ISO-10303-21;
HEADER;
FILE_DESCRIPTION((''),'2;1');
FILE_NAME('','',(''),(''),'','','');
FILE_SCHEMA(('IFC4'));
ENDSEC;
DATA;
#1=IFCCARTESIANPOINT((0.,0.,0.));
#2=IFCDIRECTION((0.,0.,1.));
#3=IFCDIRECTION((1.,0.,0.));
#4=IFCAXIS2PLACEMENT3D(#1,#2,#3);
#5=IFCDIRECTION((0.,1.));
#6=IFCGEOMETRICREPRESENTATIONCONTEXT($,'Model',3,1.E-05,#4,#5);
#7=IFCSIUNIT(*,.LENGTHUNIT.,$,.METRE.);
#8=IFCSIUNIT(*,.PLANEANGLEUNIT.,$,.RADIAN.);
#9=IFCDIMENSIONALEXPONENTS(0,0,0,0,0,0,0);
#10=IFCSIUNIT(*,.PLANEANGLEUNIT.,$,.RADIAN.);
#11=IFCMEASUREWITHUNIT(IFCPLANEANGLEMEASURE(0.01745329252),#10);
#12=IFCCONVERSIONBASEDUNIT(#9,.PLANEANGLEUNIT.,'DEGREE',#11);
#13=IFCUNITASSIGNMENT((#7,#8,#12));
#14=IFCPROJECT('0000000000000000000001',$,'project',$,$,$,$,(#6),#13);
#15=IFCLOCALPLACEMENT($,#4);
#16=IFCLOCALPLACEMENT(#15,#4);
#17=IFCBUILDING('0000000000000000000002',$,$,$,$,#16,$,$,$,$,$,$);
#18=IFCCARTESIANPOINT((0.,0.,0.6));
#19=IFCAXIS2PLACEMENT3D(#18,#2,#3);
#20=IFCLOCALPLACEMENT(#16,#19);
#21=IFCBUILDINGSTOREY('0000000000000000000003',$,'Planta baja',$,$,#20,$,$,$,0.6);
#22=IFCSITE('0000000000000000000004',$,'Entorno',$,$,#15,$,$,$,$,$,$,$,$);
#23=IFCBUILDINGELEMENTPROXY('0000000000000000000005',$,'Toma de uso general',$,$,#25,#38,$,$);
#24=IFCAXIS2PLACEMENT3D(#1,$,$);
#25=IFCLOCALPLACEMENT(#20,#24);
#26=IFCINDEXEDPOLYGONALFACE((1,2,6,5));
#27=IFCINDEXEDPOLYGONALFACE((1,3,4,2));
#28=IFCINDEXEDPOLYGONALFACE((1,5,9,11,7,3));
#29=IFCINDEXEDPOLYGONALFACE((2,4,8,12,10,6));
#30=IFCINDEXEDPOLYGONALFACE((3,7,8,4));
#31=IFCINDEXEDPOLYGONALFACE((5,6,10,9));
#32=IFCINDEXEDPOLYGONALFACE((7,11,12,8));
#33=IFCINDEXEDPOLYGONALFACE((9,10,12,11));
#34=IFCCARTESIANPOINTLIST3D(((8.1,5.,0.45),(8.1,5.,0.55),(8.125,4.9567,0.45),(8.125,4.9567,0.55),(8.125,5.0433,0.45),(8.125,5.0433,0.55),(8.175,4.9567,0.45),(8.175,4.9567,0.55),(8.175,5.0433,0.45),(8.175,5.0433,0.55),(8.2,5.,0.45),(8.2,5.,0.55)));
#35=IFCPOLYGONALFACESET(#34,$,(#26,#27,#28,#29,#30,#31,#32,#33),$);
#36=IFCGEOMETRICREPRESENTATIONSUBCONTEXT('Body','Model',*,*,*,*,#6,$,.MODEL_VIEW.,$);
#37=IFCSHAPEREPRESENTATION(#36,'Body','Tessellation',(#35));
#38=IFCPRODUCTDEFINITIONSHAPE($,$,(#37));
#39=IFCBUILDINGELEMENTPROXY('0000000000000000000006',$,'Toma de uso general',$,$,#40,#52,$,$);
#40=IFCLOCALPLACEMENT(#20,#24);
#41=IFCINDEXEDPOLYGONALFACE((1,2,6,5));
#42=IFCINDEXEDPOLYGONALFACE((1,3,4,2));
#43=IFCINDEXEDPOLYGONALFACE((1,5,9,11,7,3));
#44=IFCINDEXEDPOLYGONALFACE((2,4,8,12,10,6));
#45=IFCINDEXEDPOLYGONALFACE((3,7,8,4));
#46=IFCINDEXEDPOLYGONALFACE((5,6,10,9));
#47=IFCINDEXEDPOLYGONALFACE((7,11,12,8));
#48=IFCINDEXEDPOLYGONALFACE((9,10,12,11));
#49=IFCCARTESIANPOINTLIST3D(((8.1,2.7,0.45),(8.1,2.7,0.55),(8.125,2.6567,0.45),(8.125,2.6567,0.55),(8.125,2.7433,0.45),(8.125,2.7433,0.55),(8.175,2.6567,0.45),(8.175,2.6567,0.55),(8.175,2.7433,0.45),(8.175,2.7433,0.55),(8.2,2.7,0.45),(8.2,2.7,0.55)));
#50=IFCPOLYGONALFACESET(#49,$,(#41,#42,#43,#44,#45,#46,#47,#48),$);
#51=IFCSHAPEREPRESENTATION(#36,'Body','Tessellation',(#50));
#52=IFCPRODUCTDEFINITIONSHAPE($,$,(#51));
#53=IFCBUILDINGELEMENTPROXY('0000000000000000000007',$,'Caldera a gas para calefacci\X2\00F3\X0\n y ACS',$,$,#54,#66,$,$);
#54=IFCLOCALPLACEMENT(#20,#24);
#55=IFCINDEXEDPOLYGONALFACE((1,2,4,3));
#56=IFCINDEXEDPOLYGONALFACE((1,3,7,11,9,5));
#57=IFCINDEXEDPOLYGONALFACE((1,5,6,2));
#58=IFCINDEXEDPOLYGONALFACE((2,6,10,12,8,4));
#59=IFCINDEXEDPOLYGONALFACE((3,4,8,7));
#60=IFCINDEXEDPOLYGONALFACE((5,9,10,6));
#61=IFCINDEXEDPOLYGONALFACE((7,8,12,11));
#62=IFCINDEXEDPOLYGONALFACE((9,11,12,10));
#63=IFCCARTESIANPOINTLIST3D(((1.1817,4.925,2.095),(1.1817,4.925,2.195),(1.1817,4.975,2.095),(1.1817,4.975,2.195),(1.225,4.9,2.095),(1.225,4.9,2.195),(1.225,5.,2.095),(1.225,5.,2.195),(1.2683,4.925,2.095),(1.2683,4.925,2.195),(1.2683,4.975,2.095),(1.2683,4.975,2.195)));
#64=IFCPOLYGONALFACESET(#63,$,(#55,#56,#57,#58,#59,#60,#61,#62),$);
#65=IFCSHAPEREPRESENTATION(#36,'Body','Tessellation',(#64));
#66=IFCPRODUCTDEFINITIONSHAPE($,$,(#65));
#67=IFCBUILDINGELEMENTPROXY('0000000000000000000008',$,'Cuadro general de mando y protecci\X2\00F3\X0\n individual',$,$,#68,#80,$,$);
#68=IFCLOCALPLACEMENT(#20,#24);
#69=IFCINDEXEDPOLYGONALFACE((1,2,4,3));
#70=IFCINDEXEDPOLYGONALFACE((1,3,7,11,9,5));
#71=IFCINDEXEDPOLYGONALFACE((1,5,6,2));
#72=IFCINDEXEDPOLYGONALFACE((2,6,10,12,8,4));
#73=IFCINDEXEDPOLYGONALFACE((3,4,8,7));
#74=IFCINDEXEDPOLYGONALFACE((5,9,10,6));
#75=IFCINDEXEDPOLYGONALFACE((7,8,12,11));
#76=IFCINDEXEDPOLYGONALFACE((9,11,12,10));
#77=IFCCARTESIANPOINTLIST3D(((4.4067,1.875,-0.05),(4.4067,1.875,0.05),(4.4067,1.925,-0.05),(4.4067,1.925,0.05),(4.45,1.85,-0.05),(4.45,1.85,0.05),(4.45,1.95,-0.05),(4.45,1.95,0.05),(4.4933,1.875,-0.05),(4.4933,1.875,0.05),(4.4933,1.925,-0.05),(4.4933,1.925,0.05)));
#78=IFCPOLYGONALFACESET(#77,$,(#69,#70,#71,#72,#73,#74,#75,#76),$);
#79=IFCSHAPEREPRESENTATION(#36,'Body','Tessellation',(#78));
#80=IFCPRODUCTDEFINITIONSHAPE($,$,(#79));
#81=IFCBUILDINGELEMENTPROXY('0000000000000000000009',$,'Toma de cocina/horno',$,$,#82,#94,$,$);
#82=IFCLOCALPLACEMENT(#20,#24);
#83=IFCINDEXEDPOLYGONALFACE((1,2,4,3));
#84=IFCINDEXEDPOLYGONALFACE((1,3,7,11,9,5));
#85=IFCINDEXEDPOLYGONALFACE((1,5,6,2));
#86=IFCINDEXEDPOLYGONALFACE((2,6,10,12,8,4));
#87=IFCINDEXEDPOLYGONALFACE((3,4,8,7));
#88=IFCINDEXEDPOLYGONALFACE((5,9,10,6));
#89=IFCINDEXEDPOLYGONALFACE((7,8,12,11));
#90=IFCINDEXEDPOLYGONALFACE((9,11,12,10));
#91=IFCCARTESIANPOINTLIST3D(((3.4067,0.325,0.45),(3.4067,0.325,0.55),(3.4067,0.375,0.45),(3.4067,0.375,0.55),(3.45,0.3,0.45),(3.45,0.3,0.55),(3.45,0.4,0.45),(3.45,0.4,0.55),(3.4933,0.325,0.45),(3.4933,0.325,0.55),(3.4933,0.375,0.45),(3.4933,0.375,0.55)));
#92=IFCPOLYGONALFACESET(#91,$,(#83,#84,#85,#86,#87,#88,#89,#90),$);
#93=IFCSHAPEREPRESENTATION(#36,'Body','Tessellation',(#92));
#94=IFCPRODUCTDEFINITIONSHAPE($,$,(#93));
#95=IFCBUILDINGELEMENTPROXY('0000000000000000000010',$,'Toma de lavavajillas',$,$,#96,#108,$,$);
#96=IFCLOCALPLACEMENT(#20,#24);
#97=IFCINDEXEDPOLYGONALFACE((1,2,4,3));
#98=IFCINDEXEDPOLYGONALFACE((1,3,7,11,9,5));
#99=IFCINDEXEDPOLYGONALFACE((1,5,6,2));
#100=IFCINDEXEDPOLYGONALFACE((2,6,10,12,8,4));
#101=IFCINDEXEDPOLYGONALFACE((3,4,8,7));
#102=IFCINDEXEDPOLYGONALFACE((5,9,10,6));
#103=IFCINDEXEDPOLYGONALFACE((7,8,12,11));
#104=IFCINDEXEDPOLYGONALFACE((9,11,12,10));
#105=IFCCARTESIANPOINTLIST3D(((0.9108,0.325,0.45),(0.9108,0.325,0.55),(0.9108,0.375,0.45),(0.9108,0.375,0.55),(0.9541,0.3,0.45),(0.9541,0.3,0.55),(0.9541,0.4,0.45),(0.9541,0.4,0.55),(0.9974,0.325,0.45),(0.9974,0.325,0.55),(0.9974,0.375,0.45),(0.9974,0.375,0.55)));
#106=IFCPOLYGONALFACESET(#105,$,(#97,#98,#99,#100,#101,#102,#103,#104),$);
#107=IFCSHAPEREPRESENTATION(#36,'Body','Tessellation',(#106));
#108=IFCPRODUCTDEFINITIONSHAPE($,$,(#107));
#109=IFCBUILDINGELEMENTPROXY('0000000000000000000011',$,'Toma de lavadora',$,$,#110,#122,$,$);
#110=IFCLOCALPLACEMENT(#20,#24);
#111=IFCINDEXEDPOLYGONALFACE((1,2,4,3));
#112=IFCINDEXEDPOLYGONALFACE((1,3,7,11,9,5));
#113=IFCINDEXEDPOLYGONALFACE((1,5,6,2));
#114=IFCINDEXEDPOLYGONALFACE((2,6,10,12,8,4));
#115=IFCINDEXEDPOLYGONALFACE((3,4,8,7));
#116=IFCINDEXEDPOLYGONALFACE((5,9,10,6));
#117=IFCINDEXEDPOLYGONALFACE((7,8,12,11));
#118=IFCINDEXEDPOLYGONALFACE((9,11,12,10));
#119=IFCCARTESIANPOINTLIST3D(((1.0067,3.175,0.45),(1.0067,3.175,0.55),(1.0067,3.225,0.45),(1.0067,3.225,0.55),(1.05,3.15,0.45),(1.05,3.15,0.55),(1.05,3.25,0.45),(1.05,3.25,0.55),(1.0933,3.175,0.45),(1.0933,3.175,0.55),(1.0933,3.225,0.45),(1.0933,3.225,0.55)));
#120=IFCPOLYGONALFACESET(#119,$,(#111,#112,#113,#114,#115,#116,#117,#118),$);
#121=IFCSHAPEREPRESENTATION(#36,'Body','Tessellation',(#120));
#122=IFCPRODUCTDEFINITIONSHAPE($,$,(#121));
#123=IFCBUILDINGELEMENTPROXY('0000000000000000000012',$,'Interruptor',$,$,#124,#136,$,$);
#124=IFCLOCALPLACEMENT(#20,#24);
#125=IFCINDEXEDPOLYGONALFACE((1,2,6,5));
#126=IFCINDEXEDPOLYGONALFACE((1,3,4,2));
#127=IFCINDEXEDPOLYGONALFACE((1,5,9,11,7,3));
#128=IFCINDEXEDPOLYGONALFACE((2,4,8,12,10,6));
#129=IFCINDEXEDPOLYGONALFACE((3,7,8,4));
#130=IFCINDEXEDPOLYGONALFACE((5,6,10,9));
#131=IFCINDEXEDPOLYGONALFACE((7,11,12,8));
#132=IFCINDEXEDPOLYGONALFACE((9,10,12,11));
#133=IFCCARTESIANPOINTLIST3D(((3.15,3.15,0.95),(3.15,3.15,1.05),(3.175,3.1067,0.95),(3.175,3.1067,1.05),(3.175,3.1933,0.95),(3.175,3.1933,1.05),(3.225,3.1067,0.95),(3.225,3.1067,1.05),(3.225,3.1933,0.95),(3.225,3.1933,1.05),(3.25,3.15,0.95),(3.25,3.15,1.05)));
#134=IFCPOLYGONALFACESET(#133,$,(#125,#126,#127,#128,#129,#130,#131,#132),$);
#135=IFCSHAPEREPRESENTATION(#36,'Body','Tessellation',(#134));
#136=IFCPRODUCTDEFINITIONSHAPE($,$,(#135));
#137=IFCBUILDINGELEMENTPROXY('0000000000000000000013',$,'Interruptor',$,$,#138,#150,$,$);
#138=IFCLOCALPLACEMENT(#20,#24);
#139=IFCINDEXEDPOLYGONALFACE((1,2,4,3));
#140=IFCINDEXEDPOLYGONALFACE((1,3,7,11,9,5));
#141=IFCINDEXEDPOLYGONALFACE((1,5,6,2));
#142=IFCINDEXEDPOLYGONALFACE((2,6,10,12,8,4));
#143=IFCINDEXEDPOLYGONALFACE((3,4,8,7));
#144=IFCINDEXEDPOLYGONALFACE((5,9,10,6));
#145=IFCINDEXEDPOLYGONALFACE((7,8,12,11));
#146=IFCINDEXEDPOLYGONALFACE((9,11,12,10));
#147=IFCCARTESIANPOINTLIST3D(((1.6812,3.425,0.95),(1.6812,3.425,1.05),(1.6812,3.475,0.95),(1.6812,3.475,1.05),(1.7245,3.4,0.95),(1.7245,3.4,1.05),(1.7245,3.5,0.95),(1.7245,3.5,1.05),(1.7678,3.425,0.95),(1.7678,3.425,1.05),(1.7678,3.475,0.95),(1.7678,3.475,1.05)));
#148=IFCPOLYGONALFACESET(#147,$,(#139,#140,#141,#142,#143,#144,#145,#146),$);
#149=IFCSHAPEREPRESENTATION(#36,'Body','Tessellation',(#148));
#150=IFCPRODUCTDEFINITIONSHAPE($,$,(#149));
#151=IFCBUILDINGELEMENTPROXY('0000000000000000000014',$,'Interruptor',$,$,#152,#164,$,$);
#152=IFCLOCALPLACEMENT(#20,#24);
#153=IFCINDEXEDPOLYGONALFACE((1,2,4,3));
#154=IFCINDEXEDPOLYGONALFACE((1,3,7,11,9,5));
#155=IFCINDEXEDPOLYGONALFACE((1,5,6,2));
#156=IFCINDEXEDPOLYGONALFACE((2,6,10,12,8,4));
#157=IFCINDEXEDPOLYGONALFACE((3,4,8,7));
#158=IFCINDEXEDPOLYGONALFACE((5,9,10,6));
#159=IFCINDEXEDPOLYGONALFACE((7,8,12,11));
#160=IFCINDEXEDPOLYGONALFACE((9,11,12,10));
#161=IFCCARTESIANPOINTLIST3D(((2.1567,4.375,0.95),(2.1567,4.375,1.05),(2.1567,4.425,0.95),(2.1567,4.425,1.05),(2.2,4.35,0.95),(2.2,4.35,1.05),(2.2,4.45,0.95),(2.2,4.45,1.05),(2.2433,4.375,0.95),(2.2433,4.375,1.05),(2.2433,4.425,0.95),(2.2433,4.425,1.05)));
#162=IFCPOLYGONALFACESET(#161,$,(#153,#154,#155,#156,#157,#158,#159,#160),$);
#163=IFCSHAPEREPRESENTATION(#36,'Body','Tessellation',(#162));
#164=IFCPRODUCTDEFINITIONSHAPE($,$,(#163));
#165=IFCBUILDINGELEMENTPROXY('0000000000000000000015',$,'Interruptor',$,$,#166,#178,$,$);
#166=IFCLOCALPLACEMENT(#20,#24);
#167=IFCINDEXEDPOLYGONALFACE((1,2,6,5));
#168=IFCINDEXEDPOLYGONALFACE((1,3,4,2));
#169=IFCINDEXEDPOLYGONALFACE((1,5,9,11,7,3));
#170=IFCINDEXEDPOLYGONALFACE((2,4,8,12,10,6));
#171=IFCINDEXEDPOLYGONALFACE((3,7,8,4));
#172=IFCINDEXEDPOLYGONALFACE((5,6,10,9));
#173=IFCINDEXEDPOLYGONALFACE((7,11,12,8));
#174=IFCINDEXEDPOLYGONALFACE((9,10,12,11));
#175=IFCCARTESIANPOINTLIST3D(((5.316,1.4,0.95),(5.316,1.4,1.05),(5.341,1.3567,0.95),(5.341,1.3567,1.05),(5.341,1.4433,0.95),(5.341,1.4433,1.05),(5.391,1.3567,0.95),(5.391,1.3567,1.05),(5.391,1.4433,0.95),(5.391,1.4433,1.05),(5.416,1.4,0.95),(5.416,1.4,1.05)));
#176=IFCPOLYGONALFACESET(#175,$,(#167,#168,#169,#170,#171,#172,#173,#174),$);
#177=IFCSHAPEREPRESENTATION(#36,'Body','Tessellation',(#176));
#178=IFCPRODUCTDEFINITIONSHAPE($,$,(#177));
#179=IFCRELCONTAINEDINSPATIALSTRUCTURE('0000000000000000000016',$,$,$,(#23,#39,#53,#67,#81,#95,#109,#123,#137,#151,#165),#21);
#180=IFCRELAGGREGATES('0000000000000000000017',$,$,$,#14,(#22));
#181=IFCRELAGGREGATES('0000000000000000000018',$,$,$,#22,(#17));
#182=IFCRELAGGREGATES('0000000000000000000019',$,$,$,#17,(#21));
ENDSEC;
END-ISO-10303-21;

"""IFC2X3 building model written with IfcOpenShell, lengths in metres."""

from ifc_helpers import new_model, entity, si_unit, converted_unit, direction, frame, origin_with_axes, place, context, subcontext, project, spatial, polyline, outline, extrude, source, transform, mapped, element, save


model = new_model("IFC2X3")

# Units and contexts
model_context = context("Model", 3, precision=1e-05, world=origin_with_axes(), true_north=direction((0.0, 1.0)))
body_context = subcontext(model_context, "Body", "Model", "MODEL_VIEW")
ifc_project = project(units=[si_unit("LENGTHUNIT", "METRE"), si_unit("PLANEANGLEUNIT", "RADIAN"), converted_unit("PLANEANGLEUNIT", "DEGREE", entity("IfcPlaneAngleMeasure", 0.01745329252), si_unit("PLANEANGLEUNIT", "RADIAN"), dimensions=[0, 0, 0, 0, 0, 0, 0])], contexts=[model_context])

# Site, building, storey
site_placement = place(None, origin_with_axes())
site = spatial("IfcSite", under=ifc_project, at=site_placement, Name="Entorno")
building_placement = place(site_placement, origin_with_axes())
building = spatial("IfcBuilding", under=site, at=building_placement)
storey_placement = place(building_placement, frame((0.0, 0.0, 0.6), z_axis=(0.0, 0.0, 1.0), x_axis=(1.0, 0.0, 0.0)))
storey = spatial("IfcBuildingStorey", under=building, at=storey_placement, Name="Planta baja", Elevation=0.6)

# Building element proxies
shared_shape_1 = source(origin_with_axes(), body_context, "Body", "SolidModel", [
    extrude(outline(polyline([(0.05, 0.0), (0.025, 0.0433), (-0.025, 0.0433), (-0.05, 0.0), (-0.025, -0.0433), (0.025, -0.0433), (0.05, 0.0)])), frame((0.0, 0.0, -0.05), z_axis=(0.0, 0.0, 1.0), x_axis=(1.0, 0.0, 0.0)), (0.0, 0.0, 1.0), 0.1),
])
proxy_1_placement = place(storey_placement, frame((0.0, 0.0, -0.6), z_axis=(0.0, 0.0, 1.0), x_axis=(1.0, 0.0, 0.0)))
element("IfcBuildingElementProxy", 1, at=proxy_1_placement, inside=storey, Name="Toma de uso general", context=body_context, shape_type="Brep", body=[
    mapped(shared_shape_1, transform((8.15, 5.0, 1.1), x_axis=(-1.0, 0.0, 0.0), y_axis=(0.0, -1.0, 0.0), z_axis=(0.0, 0.0, 1.0))),
])
proxy_2_placement = place(storey_placement, frame((0.0, 0.0, -0.6), z_axis=(0.0, 0.0, 1.0), x_axis=(1.0, 0.0, 0.0)))
element("IfcBuildingElementProxy", 2, at=proxy_2_placement, inside=storey, Name="Toma de uso general", context=body_context, shape_type="Brep", body=[
    mapped(shared_shape_1, transform((8.15, 2.7, 1.1), x_axis=(-1.0, 0.0, 0.0), y_axis=(0.0, -1.0, 0.0), z_axis=(0.0, 0.0, 1.0))),
])
shared_shape_2 = source(origin_with_axes(), body_context, "Body", "SolidModel", [
    extrude(outline(polyline([(0.05, 0.0), (0.025, 0.0433), (-0.025, 0.0433), (-0.05, 0.0), (-0.025, -0.0433), (0.025, -0.0433), (0.05, 0.0)])), frame((0.0, 0.0, -0.05), z_axis=(0.0, 0.0, 1.0), x_axis=(1.0, 0.0, 0.0)), (0.0, 0.0, 1.0), 0.1),
])
proxy_3_placement = place(storey_placement, frame((0.0, 0.0, -0.6), z_axis=(0.0, 0.0, 1.0), x_axis=(1.0, 0.0, 0.0)))
element("IfcBuildingElementProxy", 3, at=proxy_3_placement, inside=storey, Name="Caldera a gas para calefacción y ACS", context=body_context, shape_type="Brep", body=[
    mapped(shared_shape_2, transform((1.225, 4.95, 2.745), x_axis=(0.0, 1.0, 0.0), y_axis=(-1.0, 0.0, 0.0), z_axis=(0.0, 0.0, 1.0))),
])
shared_shape_3 = source(origin_with_axes(), body_context, "Body", "SolidModel", [
    extrude(outline(polyline([(0.05, 0.0), (0.025, 0.0433), (-0.025, 0.0433), (-0.05, 0.0), (-0.025, -0.0433), (0.025, -0.0433), (0.05, 0.0)])), frame((0.0, 0.0, -0.05), z_axis=(0.0, 0.0, 1.0), x_axis=(1.0, 0.0, 0.0)), (0.0, 0.0, 1.0), 0.1),
])
proxy_4_placement = place(storey_placement, frame((0.0, 0.0, -0.6), z_axis=(0.0, 0.0, 1.0), x_axis=(1.0, 0.0, 0.0)))
element("IfcBuildingElementProxy", 4, at=proxy_4_placement, inside=storey, Name="Cuadro general de mando y protección individual", context=body_context, shape_type="Brep", body=[
    mapped(shared_shape_3, transform((4.45, 1.9, 0.6), x_axis=(0.0, -1.0, 0.0), y_axis=(1.0, 0.0, 0.0), z_axis=(0.0, 0.0, 1.0))),
])
shared_shape_4 = source(origin_with_axes(), body_context, "Body", "SolidModel", [
    extrude(outline(polyline([(0.05, 0.0), (0.025, 0.0433), (-0.025, 0.0433), (-0.05, 0.0), (-0.025, -0.0433), (0.025, -0.0433), (0.05, 0.0)])), frame((0.0, 0.0, -0.05), z_axis=(0.0, 0.0, 1.0), x_axis=(1.0, 0.0, 0.0)), (0.0, 0.0, 1.0), 0.1),
])
proxy_5_placement = place(storey_placement, frame((0.0, 0.0, -0.6), z_axis=(0.0, 0.0, 1.0), x_axis=(1.0, 0.0, 0.0)))
element("IfcBuildingElementProxy", 5, at=proxy_5_placement, inside=storey, Name="Toma de cocina/horno", context=body_context, shape_type="Brep", body=[
    mapped(shared_shape_4, transform((3.45, 0.35, 1.1), x_axis=(0.0, 1.0, 0.0), y_axis=(-1.0, 0.0, 0.0), z_axis=(0.0, 0.0, 1.0))),
])
shared_shape_5 = source(origin_with_axes(), body_context, "Body", "SolidModel", [
    extrude(outline(polyline([(0.05, 0.0), (0.025, 0.0433), (-0.025, 0.0433), (-0.05, 0.0), (-0.025, -0.0433), (0.025, -0.0433), (0.05, 0.0)])), frame((0.0, 0.0, -0.05), z_axis=(0.0, 0.0, 1.0), x_axis=(1.0, 0.0, 0.0)), (0.0, 0.0, 1.0), 0.1),
])
proxy_6_placement = place(storey_placement, frame((0.0, 0.0, -0.6), z_axis=(0.0, 0.0, 1.0), x_axis=(1.0, 0.0, 0.0)))
element("IfcBuildingElementProxy", 6, at=proxy_6_placement, inside=storey, Name="Toma de lavavajillas", context=body_context, shape_type="Brep", body=[
    mapped(shared_shape_5, transform((0.9541, 0.35, 1.1), x_axis=(0.0, 1.0, 0.0), y_axis=(-1.0, 0.0, 0.0), z_axis=(0.0, 0.0, 1.0))),
])
shared_shape_6 = source(origin_with_axes(), body_context, "Body", "SolidModel", [
    extrude(outline(polyline([(0.05, 0.0), (0.025, 0.0433), (-0.025, 0.0433), (-0.05, 0.0), (-0.025, -0.0433), (0.025, -0.0433), (0.05, 0.0)])), frame((0.0, 0.0, -0.05), z_axis=(0.0, 0.0, 1.0), x_axis=(1.0, 0.0, 0.0)), (0.0, 0.0, 1.0), 0.1),
])
proxy_7_placement = place(storey_placement, frame((0.0, 0.0, -0.6), z_axis=(0.0, 0.0, 1.0), x_axis=(1.0, 0.0, 0.0)))
element("IfcBuildingElementProxy", 7, at=proxy_7_placement, inside=storey, Name="Toma de lavadora", context=body_context, shape_type="Brep", body=[
    mapped(shared_shape_6, transform((1.05, 3.2, 1.1), x_axis=(0.0, -1.0, 0.0), y_axis=(1.0, 0.0, 0.0), z_axis=(0.0, 0.0, 1.0))),
])
shared_shape_7 = source(origin_with_axes(), body_context, "Body", "SolidModel", [
    extrude(outline(polyline([(0.05, 0.0), (0.025, 0.0433), (-0.025, 0.0433), (-0.05, 0.0), (-0.025, -0.0433), (0.025, -0.0433), (0.05, 0.0)])), frame((0.0, 0.0, -0.05), z_axis=(0.0, 0.0, 1.0), x_axis=(1.0, 0.0, 0.0)), (0.0, 0.0, 1.0), 0.1),
])
proxy_8_placement = place(storey_placement, frame((0.0, 0.0, -0.6), z_axis=(0.0, 0.0, 1.0), x_axis=(1.0, 0.0, 0.0)))
element("IfcBuildingElementProxy", 8, at=proxy_8_placement, inside=storey, Name="Interruptor", context=body_context, shape_type="Brep", body=[
    mapped(shared_shape_7, transform((3.2, 3.15, 1.6), x_axis=(1.0, 0.0, 0.0), y_axis=(0.0, 1.0, 0.0), z_axis=(0.0, 0.0, 1.0))),
])
proxy_9_placement = place(storey_placement, frame((0.0, 0.0, -0.6), z_axis=(0.0, 0.0, 1.0), x_axis=(1.0, 0.0, 0.0)))
element("IfcBuildingElementProxy", 9, at=proxy_9_placement, inside=storey, Name="Interruptor", context=body_context, shape_type="Brep", body=[
    mapped(shared_shape_7, transform((1.7245, 3.45, 1.6), x_axis=(0.0, 1.0, 0.0), y_axis=(-1.0, 0.0, 0.0), z_axis=(0.0, 0.0, 1.0))),
])
proxy_10_placement = place(storey_placement, frame((0.0, 0.0, -0.6), z_axis=(0.0, 0.0, 1.0), x_axis=(1.0, 0.0, 0.0)))
element("IfcBuildingElementProxy", 10, at=proxy_10_placement, inside=storey, Name="Interruptor", context=body_context, shape_type="Brep", body=[
    mapped(shared_shape_7, transform((2.2, 4.4, 1.6), x_axis=(0.0, 1.0, 0.0), y_axis=(-1.0, 0.0, 0.0), z_axis=(0.0, 0.0, 1.0))),
])
proxy_11_placement = place(storey_placement, frame((0.0, 0.0, -0.6), z_axis=(0.0, 0.0, 1.0), x_axis=(1.0, 0.0, 0.0)))
element("IfcBuildingElementProxy", 11, at=proxy_11_placement, inside=storey, Name="Interruptor", context=body_context, shape_type="Brep", body=[
    mapped(shared_shape_7, transform((5.366, 1.4, 1.6), x_axis=(-1.0, 0.0, 0.0), y_axis=(0.0, -1.0, 0.0), z_axis=(0.0, 0.0, 1.0))),
])

save(model, "model.ifc")
